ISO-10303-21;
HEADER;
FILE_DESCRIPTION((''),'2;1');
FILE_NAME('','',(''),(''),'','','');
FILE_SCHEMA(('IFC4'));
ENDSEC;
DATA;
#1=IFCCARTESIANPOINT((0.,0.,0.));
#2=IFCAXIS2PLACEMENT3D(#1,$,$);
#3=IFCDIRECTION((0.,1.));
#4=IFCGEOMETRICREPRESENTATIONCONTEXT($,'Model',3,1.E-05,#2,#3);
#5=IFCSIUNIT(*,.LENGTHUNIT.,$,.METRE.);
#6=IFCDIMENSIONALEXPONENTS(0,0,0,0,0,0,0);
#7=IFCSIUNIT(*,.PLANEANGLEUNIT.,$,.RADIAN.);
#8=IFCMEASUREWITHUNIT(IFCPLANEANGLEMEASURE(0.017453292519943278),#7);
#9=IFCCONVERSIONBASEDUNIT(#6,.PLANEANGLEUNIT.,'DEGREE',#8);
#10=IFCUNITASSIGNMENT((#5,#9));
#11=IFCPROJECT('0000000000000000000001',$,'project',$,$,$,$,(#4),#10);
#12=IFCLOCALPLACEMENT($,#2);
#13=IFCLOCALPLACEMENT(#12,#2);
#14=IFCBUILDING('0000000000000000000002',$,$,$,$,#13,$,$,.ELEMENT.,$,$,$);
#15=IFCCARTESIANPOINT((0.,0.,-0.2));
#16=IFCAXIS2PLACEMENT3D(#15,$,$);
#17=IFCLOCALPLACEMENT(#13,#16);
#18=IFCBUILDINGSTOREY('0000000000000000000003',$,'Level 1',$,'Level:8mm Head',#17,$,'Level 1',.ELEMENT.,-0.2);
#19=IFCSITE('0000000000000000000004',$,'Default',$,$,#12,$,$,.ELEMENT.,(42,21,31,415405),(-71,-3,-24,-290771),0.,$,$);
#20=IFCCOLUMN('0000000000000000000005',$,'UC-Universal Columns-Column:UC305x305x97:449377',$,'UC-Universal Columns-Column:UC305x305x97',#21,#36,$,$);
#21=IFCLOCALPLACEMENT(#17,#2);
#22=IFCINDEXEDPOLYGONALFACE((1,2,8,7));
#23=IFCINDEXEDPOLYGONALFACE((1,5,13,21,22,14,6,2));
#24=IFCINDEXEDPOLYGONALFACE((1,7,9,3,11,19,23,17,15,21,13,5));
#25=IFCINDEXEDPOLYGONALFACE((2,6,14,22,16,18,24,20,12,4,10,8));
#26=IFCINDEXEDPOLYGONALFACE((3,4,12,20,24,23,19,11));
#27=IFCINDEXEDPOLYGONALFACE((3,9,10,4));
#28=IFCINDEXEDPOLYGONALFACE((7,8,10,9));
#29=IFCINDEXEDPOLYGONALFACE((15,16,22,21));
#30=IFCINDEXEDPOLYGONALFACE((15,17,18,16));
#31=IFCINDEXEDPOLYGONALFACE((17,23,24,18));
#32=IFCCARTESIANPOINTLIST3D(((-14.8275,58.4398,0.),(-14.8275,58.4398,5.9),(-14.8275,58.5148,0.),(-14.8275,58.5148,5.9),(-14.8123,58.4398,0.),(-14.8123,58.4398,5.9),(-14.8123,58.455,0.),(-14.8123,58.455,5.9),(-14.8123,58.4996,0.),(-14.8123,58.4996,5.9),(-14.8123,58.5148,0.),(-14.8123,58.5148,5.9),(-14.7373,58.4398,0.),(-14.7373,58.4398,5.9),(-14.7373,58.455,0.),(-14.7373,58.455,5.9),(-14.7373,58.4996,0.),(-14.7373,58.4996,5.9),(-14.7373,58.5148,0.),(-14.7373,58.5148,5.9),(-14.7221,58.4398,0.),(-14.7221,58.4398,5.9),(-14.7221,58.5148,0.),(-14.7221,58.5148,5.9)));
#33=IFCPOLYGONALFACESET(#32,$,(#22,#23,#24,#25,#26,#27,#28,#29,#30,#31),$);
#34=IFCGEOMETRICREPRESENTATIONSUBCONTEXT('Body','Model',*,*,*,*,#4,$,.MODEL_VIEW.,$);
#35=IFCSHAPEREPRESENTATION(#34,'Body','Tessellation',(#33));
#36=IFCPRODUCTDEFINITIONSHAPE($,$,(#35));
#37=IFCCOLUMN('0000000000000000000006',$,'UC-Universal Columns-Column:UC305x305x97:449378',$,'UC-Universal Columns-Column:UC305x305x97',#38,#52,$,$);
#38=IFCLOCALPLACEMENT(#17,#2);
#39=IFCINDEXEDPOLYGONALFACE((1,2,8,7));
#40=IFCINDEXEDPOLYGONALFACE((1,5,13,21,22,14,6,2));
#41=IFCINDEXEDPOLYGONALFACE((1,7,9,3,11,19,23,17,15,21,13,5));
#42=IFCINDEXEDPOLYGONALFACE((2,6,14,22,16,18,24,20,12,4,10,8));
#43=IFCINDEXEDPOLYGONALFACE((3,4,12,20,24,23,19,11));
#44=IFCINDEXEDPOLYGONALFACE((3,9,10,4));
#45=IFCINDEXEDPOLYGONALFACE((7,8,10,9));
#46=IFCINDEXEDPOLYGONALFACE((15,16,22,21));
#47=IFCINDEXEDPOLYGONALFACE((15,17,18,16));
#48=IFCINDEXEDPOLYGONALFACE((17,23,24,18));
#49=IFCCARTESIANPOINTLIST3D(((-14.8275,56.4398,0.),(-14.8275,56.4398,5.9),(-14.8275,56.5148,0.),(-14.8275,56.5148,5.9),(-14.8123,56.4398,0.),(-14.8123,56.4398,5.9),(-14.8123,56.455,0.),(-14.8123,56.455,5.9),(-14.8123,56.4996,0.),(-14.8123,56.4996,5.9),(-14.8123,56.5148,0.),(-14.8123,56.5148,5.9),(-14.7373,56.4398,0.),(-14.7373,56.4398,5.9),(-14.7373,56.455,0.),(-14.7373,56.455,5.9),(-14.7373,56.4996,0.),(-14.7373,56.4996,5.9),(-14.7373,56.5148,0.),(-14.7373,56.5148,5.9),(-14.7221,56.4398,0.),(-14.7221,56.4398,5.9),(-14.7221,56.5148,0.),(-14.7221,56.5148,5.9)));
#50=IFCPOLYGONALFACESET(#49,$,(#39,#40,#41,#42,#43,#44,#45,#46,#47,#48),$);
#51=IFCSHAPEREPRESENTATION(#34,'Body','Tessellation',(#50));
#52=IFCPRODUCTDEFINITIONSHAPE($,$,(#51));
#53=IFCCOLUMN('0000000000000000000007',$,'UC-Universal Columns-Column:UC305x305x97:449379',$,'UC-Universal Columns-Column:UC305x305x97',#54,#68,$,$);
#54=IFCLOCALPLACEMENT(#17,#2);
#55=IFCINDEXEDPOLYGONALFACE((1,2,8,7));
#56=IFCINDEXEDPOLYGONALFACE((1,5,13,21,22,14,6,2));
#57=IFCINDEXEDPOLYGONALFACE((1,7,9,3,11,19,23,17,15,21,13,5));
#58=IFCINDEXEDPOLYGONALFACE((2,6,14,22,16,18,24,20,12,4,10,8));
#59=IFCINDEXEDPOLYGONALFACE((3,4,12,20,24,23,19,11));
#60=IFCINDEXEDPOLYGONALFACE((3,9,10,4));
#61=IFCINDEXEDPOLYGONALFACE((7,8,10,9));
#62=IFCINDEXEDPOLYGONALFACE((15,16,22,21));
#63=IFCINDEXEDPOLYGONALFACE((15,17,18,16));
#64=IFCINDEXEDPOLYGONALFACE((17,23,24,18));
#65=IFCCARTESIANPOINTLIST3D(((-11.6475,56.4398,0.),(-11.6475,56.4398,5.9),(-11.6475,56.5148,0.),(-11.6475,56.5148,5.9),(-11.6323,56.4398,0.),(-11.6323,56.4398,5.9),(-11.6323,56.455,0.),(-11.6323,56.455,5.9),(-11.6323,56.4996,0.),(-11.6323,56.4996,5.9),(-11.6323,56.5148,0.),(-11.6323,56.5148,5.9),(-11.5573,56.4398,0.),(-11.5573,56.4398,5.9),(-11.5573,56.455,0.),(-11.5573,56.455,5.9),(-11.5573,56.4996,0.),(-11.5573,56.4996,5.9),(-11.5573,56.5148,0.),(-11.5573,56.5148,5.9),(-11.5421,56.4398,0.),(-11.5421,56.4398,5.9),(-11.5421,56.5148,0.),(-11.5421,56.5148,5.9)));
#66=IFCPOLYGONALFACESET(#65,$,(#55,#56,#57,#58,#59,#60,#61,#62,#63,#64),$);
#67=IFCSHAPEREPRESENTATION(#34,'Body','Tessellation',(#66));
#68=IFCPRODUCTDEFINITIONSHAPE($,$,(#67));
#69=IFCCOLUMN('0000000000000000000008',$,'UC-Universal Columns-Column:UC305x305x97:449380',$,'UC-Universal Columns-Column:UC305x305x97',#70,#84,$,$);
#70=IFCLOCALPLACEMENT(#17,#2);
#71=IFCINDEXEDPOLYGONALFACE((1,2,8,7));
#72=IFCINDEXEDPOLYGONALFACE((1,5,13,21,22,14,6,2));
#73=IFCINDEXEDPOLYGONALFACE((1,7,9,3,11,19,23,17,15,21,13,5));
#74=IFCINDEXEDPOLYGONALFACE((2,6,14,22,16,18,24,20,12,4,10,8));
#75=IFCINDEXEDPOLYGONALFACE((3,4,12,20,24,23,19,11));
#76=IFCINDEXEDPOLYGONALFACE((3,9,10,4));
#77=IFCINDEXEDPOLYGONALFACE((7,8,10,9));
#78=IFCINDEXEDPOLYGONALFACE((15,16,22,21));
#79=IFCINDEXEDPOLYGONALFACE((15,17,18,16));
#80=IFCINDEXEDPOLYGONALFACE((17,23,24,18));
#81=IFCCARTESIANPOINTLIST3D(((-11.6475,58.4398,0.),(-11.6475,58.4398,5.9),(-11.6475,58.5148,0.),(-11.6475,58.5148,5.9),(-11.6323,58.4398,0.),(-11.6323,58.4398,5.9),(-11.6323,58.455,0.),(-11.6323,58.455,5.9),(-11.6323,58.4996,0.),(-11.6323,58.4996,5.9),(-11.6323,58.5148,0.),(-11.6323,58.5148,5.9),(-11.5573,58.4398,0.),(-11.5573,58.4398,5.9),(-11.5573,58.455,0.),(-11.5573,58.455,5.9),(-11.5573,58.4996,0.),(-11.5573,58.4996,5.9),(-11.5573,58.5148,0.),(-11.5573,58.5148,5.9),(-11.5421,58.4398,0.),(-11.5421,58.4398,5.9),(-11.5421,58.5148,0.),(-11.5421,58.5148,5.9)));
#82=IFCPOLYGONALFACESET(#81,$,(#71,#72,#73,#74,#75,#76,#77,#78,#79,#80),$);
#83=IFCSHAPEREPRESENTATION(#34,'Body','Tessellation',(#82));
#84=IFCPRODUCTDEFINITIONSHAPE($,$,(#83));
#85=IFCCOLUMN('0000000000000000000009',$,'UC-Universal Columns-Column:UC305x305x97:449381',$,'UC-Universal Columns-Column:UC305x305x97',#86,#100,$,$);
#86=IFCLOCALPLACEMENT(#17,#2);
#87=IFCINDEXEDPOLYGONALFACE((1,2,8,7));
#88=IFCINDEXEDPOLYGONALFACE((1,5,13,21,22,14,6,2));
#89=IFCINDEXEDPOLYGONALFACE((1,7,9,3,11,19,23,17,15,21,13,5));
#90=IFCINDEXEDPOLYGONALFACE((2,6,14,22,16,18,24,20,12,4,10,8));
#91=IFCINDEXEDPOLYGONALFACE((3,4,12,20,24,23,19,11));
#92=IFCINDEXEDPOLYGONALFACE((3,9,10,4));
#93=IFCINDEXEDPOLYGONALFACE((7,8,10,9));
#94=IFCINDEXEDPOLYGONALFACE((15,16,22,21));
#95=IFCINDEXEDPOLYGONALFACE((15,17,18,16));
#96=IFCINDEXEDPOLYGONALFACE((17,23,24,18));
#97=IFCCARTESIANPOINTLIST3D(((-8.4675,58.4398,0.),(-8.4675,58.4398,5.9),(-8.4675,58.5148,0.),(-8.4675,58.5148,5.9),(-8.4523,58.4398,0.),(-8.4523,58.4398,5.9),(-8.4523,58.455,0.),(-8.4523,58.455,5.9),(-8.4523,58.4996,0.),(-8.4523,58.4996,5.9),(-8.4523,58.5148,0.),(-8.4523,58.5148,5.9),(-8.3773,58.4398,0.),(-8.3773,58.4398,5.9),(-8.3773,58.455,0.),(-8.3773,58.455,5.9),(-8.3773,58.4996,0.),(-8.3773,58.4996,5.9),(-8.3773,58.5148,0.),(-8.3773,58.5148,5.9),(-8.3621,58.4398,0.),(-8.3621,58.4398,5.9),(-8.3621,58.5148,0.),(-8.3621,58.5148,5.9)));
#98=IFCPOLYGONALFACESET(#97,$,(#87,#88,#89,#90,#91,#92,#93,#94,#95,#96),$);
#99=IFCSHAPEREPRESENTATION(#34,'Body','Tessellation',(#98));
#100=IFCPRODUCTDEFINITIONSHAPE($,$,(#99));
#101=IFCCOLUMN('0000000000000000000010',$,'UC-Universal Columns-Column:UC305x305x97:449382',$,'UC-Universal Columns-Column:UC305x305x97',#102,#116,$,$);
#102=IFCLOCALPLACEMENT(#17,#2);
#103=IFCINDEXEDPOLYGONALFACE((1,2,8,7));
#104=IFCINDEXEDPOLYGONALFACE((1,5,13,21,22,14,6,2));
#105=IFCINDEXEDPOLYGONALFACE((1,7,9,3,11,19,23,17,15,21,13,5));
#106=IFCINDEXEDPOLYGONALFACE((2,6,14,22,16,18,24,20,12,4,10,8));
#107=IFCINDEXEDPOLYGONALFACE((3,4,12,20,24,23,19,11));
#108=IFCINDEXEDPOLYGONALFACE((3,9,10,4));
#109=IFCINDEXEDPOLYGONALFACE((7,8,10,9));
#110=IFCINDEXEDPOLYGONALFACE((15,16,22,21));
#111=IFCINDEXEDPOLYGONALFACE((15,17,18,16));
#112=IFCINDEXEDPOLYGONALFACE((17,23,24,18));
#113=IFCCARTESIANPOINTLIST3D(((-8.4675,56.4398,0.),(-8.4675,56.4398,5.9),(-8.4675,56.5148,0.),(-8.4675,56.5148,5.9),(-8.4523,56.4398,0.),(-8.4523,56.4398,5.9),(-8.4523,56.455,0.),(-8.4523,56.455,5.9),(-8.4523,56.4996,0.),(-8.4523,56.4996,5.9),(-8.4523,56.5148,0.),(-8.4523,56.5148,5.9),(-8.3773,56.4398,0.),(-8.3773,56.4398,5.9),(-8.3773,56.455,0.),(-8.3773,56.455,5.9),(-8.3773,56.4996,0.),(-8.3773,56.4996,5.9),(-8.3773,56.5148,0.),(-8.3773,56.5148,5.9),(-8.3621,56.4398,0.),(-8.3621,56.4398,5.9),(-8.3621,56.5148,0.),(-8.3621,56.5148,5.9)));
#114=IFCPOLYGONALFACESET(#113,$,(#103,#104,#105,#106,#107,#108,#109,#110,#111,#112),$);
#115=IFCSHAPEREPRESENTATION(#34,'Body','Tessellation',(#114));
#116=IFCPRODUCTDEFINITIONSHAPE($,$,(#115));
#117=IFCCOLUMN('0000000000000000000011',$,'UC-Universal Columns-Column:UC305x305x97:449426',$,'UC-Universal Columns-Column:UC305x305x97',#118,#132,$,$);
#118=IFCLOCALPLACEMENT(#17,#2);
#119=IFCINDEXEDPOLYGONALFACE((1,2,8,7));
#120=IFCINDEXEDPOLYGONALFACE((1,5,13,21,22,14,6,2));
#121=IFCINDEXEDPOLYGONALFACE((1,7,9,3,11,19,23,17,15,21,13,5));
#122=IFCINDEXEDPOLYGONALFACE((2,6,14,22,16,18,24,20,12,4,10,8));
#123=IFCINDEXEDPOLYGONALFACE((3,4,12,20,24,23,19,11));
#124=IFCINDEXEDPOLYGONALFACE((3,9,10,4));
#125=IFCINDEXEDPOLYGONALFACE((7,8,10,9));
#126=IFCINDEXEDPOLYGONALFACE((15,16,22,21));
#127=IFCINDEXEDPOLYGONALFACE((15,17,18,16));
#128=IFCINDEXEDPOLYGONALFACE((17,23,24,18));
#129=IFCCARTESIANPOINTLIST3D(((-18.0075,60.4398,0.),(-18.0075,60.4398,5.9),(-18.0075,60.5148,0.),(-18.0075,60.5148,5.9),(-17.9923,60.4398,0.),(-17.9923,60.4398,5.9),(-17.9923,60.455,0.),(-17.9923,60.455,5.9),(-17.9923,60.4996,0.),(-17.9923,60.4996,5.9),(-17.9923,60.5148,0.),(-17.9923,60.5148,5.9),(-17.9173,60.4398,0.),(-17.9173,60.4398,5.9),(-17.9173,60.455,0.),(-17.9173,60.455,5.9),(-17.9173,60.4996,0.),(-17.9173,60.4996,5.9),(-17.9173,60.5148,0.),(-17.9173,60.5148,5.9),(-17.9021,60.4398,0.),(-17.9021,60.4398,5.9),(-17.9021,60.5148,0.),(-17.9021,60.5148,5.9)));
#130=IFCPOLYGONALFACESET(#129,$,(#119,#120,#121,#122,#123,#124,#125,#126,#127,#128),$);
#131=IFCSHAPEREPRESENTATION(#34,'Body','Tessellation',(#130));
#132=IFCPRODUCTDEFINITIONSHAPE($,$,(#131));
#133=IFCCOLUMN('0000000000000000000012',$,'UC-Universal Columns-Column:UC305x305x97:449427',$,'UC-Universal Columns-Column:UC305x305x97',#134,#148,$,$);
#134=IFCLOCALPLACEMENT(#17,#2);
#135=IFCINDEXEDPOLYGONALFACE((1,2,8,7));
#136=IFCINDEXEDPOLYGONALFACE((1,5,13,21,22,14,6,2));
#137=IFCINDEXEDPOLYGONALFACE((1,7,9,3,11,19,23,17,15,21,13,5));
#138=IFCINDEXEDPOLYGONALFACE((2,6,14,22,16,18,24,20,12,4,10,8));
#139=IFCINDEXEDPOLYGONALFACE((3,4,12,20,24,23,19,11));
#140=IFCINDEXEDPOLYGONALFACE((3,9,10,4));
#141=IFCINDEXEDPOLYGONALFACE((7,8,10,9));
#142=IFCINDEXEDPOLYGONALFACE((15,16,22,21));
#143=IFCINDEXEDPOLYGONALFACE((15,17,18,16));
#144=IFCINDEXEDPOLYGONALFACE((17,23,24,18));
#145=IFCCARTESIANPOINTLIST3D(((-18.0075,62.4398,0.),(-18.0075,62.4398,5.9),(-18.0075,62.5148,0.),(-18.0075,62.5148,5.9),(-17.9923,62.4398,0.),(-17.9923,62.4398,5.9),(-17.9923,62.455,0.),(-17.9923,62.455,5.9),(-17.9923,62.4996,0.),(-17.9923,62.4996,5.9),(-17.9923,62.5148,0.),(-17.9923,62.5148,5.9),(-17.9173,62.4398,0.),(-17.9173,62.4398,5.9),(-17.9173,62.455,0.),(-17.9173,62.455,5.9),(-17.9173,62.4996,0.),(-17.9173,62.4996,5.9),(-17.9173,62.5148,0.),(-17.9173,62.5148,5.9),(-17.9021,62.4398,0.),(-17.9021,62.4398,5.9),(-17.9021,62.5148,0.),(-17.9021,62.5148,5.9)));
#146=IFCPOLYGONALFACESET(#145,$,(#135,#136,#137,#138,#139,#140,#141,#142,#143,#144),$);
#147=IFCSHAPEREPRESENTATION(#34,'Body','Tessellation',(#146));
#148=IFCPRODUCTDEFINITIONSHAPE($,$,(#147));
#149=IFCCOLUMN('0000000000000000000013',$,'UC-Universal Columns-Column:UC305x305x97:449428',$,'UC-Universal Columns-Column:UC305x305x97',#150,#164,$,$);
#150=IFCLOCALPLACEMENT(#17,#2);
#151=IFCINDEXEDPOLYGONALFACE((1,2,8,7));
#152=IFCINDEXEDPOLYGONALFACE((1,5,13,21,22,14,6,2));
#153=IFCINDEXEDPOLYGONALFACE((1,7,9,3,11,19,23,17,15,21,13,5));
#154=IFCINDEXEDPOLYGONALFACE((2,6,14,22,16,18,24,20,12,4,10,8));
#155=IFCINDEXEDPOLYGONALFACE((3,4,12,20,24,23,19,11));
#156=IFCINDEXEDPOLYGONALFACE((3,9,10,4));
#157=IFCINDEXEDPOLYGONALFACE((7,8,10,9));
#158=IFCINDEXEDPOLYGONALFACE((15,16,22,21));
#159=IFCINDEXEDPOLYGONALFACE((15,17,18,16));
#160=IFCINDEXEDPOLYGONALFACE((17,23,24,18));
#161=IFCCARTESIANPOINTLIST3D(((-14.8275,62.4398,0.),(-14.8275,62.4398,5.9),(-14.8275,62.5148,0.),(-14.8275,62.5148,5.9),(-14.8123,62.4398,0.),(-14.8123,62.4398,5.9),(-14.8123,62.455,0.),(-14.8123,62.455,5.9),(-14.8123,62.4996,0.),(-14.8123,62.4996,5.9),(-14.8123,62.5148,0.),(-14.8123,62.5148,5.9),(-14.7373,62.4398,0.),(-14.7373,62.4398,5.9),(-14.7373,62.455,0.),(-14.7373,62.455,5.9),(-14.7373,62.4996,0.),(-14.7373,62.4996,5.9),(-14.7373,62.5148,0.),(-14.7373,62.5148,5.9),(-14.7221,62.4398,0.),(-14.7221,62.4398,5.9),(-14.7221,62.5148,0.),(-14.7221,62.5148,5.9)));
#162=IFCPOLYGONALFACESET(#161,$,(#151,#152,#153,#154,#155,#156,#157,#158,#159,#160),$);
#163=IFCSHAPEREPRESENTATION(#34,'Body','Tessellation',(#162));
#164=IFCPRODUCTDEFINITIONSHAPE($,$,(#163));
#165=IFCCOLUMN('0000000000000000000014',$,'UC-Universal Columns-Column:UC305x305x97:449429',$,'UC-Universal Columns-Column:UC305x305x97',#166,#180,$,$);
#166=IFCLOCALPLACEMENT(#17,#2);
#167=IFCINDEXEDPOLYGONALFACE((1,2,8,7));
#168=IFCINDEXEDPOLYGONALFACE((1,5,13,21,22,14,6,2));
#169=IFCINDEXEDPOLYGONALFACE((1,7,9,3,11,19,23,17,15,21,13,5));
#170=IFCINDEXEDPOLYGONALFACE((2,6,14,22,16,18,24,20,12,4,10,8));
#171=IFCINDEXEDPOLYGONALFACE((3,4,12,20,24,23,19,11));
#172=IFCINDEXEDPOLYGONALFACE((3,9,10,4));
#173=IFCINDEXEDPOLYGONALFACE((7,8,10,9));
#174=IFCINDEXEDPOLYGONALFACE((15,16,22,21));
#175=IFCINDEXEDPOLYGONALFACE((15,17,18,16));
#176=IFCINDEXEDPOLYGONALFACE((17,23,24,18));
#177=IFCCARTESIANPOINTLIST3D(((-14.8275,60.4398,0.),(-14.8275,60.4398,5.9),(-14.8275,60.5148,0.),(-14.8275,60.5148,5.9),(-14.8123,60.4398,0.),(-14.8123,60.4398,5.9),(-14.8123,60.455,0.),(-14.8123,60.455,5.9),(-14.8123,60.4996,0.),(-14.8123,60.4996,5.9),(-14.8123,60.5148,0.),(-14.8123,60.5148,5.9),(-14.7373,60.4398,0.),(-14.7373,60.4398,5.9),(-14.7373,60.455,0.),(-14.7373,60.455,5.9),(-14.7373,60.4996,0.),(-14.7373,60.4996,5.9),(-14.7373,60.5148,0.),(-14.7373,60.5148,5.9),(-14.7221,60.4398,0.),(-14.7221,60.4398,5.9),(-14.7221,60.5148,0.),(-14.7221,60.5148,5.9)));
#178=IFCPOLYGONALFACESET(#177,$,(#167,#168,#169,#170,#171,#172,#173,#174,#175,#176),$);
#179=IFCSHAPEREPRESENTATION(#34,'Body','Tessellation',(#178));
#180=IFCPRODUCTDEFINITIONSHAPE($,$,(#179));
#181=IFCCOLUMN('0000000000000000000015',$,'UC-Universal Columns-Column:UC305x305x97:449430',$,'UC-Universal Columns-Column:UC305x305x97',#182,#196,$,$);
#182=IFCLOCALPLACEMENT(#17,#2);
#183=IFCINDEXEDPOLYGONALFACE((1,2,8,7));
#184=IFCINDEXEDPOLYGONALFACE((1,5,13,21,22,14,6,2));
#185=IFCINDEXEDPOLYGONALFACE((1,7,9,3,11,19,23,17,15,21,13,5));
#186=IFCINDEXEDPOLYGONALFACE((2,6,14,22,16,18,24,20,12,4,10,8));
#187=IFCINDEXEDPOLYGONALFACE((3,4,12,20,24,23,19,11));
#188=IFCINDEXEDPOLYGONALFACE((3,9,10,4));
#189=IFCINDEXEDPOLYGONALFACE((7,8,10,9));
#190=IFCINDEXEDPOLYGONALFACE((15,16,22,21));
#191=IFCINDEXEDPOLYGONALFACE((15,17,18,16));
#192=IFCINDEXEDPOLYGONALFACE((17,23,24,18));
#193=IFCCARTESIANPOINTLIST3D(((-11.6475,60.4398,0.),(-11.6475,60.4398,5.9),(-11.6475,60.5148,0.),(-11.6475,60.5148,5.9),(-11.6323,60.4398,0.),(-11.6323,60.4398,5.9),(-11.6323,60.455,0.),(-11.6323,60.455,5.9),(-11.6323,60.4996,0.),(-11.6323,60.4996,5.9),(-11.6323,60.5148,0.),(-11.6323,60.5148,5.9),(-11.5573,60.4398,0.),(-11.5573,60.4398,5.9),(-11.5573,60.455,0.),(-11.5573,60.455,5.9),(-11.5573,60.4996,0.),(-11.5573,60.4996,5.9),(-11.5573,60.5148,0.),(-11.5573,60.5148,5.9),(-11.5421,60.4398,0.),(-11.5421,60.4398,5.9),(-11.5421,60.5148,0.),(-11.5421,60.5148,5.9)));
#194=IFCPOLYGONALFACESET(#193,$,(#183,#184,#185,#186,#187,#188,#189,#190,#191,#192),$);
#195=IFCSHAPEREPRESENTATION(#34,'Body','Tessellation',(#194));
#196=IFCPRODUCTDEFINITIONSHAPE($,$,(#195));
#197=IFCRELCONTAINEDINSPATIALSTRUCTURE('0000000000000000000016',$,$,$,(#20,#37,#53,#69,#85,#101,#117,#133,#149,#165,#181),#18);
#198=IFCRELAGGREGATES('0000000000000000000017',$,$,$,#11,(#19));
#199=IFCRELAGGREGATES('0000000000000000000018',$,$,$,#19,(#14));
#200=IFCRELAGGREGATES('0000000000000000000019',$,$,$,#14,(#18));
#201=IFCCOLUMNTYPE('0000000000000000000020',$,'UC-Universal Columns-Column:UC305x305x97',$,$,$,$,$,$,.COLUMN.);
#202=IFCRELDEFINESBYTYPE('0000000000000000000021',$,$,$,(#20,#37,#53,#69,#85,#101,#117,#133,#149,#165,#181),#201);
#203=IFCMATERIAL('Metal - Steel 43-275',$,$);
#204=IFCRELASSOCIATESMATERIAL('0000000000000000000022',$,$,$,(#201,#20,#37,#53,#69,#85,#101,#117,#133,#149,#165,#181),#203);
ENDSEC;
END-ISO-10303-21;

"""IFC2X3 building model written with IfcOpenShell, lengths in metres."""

from ifc_helpers import new_model, entity, si_unit, converted_unit, direction, frame, frame_2d, origin, place, context, subcontext, project, spatial, polyline, circle_curve, parameter, trimmed, segment, composite_curve, outline, extrude, source, transform, mapped, material, type_object, type_shapes, element, save


model = new_model("IFC2X3")

# Units and contexts
model_context = context("Model", 3, precision=1e-05, world=origin(), true_north=direction((0.0, 1.0)))
body_context = subcontext(model_context, "Body", "Model", "MODEL_VIEW")
ifc_project = project(units=[si_unit("LENGTHUNIT", "METRE"), converted_unit("PLANEANGLEUNIT", "DEGREE", entity("IfcPlaneAngleMeasure", 0.017453292519943278), si_unit("PLANEANGLEUNIT", "RADIAN"), dimensions=[0, 0, 0, 0, 0, 0, 0])], contexts=[model_context])

# Site, building, storey
site_placement = place(None, origin())
site = spatial("IfcSite", under=ifc_project, at=site_placement, Name="Default", CompositionType="ELEMENT", RefLatitude=(42, 21, 31, 415405), RefLongitude=(-71, -3, -24, -290771), RefElevation=0.0)
building_placement = place(site_placement, origin())
building = spatial("IfcBuilding", under=site, at=building_placement, CompositionType="ELEMENT")
storey_placement = place(building_placement, frame((0.0, 0.0, -0.2)))
storey = spatial("IfcBuildingStorey", under=building, at=storey_placement, Name="Level 1", ObjectType="Level:8mm Head", LongName="Level 1", CompositionType="ELEMENT", Elevation=-0.2)

# Columns
ifc_material = material(Name="Metal - Steel 43-275")
column_type = type_object("IfcColumnType", Name="UC-Universal Columns-Column:UC305x305x97", PredefinedType="COLUMN", material=ifc_material)
shared_shape = source(origin(), body_context, "Body", "SweptSolid", [
    extrude(outline(composite_curve([segment(polyline([(-0.0375, -0.0375), (0.0375, -0.0375)]), True, "CONTINUOUS"), segment(polyline([(0.0375, -0.0375), (0.0527, -0.0375)]), True, "CONTINUOUS"), segment(trimmed(circle_curve(frame_2d((0.0527, -0.0223), x_axis=(-1.0, 0.0)), 0.0152), [parameter(0.0)], [parameter(90.0)], True, "PARAMETER"), False, "CONTINUOUS"), segment(polyline([(0.0375, -0.0223), (0.0375, 0.0223)]), True, "CONTINUOUS"), segment(trimmed(circle_curve(frame_2d((0.0527, 0.0223), x_axis=(-1.0, 0.0)), 0.0152), [parameter(270.0)], [parameter(0.0)], True, "PARAMETER"), False, "CONTINUOUS"), segment(polyline([(0.0527, 0.0375), (0.0375, 0.0375)]), True, "CONTINUOUS"), segment(polyline([(0.0375, 0.0375), (-0.0375, 0.0375)]), True, "CONTINUOUS"), segment(polyline([(-0.0375, 0.0375), (-0.0527, 0.0375)]), True, "CONTINUOUS"), segment(trimmed(circle_curve(frame_2d((-0.0527, 0.0223), x_axis=(-1.0, 0.0)), 0.0152), [parameter(180.0)], [parameter(270.0)], True, "PARAMETER"), False, "CONTINUOUS"), segment(polyline([(-0.0375, 0.0223), (-0.0375, -0.0223)]), True, "CONTINUOUS"), segment(trimmed(circle_curve(frame_2d((-0.0527, -0.0223), x_axis=(-1.0, 0.0)), 0.0152), [parameter(90.0)], [parameter(180.0)], True, "PARAMETER"), False, "CONTINUOUS"), segment(polyline([(-0.0527, -0.0375), (-0.0375, -0.0375)]), True, "CONTINUOUS")], self_intersect=False)), frame((0.0, 0.0, -0.2), z_axis=(0.0, 0.0, 1.0), x_axis=(-1.0, 0.0, 0.0)), (0.0, 0.0, 1.0), 5.9),
])
type_shapes(column_type, [shared_shape])
for number, where, z_axis, x_axis, name in (
    (1, (-14.7748, 58.4773, 0.2), (0.0, 0.0, 1.0), (-1.0, 0.0, 0.0), "UC-Universal Columns-Column:UC305x305x97:449377"),
    (2, (-14.7748, 56.4773, 0.2), (0.0, 0.0, 1.0), (-1.0, 0.0, 0.0), "UC-Universal Columns-Column:UC305x305x97:449378"),
    (3, (-11.5948, 56.4773, 0.2), (0.0, 0.0, 1.0), (-1.0, 0.0, 0.0), "UC-Universal Columns-Column:UC305x305x97:449379"),
    (4, (-11.5948, 58.4773, 0.2), (0.0, 0.0, 1.0), (-1.0, 0.0, 0.0), "UC-Universal Columns-Column:UC305x305x97:449380"),
    (5, (-8.4148, 58.4773, 0.2), (0.0, 0.0, 1.0), (-1.0, 0.0, 0.0), "UC-Universal Columns-Column:UC305x305x97:449381"),
    (6, (-8.4148, 56.4773, 0.2), (0.0, 0.0, 1.0), (-1.0, 0.0, 0.0), "UC-Universal Columns-Column:UC305x305x97:449382"),
    (7, (-17.9548, 60.4773, 0.2), (0.0, 0.0, 1.0), (-1.0, 0.0, 0.0), "UC-Universal Columns-Column:UC305x305x97:449426"),
    (8, (-17.9548, 62.4773, 0.2), (0.0, 0.0, 1.0), (-1.0, 0.0, 0.0), "UC-Universal Columns-Column:UC305x305x97:449427"),
    (9, (-14.7748, 62.4773, 0.2), (0.0, 0.0, 1.0), (-1.0, 0.0, 0.0), "UC-Universal Columns-Column:UC305x305x97:449428"),
    (10, (-14.7748, 60.4773, 0.2), (0.0, 0.0, 1.0), (-1.0, 0.0, 0.0), "UC-Universal Columns-Column:UC305x305x97:449429"),
    (11, (-11.5948, 60.4773, 0.2), (0.0, 0.0, 1.0), (-1.0, 0.0, 0.0), "UC-Universal Columns-Column:UC305x305x97:449430"),
):
    element("IfcColumn", number, at=place(storey_placement, frame(where, z_axis=z_axis, x_axis=x_axis)), inside=storey, type_object=column_type, material=ifc_material, Name=name, ObjectType="UC-Universal Columns-Column:UC305x305x97", context=body_context, shape_type="MappedRepresentation", body=[
        mapped(shared_shape, transform((0.0, 0.0, 0.0), scale=1.0)),
    ])

save(model, "model.ifc")
